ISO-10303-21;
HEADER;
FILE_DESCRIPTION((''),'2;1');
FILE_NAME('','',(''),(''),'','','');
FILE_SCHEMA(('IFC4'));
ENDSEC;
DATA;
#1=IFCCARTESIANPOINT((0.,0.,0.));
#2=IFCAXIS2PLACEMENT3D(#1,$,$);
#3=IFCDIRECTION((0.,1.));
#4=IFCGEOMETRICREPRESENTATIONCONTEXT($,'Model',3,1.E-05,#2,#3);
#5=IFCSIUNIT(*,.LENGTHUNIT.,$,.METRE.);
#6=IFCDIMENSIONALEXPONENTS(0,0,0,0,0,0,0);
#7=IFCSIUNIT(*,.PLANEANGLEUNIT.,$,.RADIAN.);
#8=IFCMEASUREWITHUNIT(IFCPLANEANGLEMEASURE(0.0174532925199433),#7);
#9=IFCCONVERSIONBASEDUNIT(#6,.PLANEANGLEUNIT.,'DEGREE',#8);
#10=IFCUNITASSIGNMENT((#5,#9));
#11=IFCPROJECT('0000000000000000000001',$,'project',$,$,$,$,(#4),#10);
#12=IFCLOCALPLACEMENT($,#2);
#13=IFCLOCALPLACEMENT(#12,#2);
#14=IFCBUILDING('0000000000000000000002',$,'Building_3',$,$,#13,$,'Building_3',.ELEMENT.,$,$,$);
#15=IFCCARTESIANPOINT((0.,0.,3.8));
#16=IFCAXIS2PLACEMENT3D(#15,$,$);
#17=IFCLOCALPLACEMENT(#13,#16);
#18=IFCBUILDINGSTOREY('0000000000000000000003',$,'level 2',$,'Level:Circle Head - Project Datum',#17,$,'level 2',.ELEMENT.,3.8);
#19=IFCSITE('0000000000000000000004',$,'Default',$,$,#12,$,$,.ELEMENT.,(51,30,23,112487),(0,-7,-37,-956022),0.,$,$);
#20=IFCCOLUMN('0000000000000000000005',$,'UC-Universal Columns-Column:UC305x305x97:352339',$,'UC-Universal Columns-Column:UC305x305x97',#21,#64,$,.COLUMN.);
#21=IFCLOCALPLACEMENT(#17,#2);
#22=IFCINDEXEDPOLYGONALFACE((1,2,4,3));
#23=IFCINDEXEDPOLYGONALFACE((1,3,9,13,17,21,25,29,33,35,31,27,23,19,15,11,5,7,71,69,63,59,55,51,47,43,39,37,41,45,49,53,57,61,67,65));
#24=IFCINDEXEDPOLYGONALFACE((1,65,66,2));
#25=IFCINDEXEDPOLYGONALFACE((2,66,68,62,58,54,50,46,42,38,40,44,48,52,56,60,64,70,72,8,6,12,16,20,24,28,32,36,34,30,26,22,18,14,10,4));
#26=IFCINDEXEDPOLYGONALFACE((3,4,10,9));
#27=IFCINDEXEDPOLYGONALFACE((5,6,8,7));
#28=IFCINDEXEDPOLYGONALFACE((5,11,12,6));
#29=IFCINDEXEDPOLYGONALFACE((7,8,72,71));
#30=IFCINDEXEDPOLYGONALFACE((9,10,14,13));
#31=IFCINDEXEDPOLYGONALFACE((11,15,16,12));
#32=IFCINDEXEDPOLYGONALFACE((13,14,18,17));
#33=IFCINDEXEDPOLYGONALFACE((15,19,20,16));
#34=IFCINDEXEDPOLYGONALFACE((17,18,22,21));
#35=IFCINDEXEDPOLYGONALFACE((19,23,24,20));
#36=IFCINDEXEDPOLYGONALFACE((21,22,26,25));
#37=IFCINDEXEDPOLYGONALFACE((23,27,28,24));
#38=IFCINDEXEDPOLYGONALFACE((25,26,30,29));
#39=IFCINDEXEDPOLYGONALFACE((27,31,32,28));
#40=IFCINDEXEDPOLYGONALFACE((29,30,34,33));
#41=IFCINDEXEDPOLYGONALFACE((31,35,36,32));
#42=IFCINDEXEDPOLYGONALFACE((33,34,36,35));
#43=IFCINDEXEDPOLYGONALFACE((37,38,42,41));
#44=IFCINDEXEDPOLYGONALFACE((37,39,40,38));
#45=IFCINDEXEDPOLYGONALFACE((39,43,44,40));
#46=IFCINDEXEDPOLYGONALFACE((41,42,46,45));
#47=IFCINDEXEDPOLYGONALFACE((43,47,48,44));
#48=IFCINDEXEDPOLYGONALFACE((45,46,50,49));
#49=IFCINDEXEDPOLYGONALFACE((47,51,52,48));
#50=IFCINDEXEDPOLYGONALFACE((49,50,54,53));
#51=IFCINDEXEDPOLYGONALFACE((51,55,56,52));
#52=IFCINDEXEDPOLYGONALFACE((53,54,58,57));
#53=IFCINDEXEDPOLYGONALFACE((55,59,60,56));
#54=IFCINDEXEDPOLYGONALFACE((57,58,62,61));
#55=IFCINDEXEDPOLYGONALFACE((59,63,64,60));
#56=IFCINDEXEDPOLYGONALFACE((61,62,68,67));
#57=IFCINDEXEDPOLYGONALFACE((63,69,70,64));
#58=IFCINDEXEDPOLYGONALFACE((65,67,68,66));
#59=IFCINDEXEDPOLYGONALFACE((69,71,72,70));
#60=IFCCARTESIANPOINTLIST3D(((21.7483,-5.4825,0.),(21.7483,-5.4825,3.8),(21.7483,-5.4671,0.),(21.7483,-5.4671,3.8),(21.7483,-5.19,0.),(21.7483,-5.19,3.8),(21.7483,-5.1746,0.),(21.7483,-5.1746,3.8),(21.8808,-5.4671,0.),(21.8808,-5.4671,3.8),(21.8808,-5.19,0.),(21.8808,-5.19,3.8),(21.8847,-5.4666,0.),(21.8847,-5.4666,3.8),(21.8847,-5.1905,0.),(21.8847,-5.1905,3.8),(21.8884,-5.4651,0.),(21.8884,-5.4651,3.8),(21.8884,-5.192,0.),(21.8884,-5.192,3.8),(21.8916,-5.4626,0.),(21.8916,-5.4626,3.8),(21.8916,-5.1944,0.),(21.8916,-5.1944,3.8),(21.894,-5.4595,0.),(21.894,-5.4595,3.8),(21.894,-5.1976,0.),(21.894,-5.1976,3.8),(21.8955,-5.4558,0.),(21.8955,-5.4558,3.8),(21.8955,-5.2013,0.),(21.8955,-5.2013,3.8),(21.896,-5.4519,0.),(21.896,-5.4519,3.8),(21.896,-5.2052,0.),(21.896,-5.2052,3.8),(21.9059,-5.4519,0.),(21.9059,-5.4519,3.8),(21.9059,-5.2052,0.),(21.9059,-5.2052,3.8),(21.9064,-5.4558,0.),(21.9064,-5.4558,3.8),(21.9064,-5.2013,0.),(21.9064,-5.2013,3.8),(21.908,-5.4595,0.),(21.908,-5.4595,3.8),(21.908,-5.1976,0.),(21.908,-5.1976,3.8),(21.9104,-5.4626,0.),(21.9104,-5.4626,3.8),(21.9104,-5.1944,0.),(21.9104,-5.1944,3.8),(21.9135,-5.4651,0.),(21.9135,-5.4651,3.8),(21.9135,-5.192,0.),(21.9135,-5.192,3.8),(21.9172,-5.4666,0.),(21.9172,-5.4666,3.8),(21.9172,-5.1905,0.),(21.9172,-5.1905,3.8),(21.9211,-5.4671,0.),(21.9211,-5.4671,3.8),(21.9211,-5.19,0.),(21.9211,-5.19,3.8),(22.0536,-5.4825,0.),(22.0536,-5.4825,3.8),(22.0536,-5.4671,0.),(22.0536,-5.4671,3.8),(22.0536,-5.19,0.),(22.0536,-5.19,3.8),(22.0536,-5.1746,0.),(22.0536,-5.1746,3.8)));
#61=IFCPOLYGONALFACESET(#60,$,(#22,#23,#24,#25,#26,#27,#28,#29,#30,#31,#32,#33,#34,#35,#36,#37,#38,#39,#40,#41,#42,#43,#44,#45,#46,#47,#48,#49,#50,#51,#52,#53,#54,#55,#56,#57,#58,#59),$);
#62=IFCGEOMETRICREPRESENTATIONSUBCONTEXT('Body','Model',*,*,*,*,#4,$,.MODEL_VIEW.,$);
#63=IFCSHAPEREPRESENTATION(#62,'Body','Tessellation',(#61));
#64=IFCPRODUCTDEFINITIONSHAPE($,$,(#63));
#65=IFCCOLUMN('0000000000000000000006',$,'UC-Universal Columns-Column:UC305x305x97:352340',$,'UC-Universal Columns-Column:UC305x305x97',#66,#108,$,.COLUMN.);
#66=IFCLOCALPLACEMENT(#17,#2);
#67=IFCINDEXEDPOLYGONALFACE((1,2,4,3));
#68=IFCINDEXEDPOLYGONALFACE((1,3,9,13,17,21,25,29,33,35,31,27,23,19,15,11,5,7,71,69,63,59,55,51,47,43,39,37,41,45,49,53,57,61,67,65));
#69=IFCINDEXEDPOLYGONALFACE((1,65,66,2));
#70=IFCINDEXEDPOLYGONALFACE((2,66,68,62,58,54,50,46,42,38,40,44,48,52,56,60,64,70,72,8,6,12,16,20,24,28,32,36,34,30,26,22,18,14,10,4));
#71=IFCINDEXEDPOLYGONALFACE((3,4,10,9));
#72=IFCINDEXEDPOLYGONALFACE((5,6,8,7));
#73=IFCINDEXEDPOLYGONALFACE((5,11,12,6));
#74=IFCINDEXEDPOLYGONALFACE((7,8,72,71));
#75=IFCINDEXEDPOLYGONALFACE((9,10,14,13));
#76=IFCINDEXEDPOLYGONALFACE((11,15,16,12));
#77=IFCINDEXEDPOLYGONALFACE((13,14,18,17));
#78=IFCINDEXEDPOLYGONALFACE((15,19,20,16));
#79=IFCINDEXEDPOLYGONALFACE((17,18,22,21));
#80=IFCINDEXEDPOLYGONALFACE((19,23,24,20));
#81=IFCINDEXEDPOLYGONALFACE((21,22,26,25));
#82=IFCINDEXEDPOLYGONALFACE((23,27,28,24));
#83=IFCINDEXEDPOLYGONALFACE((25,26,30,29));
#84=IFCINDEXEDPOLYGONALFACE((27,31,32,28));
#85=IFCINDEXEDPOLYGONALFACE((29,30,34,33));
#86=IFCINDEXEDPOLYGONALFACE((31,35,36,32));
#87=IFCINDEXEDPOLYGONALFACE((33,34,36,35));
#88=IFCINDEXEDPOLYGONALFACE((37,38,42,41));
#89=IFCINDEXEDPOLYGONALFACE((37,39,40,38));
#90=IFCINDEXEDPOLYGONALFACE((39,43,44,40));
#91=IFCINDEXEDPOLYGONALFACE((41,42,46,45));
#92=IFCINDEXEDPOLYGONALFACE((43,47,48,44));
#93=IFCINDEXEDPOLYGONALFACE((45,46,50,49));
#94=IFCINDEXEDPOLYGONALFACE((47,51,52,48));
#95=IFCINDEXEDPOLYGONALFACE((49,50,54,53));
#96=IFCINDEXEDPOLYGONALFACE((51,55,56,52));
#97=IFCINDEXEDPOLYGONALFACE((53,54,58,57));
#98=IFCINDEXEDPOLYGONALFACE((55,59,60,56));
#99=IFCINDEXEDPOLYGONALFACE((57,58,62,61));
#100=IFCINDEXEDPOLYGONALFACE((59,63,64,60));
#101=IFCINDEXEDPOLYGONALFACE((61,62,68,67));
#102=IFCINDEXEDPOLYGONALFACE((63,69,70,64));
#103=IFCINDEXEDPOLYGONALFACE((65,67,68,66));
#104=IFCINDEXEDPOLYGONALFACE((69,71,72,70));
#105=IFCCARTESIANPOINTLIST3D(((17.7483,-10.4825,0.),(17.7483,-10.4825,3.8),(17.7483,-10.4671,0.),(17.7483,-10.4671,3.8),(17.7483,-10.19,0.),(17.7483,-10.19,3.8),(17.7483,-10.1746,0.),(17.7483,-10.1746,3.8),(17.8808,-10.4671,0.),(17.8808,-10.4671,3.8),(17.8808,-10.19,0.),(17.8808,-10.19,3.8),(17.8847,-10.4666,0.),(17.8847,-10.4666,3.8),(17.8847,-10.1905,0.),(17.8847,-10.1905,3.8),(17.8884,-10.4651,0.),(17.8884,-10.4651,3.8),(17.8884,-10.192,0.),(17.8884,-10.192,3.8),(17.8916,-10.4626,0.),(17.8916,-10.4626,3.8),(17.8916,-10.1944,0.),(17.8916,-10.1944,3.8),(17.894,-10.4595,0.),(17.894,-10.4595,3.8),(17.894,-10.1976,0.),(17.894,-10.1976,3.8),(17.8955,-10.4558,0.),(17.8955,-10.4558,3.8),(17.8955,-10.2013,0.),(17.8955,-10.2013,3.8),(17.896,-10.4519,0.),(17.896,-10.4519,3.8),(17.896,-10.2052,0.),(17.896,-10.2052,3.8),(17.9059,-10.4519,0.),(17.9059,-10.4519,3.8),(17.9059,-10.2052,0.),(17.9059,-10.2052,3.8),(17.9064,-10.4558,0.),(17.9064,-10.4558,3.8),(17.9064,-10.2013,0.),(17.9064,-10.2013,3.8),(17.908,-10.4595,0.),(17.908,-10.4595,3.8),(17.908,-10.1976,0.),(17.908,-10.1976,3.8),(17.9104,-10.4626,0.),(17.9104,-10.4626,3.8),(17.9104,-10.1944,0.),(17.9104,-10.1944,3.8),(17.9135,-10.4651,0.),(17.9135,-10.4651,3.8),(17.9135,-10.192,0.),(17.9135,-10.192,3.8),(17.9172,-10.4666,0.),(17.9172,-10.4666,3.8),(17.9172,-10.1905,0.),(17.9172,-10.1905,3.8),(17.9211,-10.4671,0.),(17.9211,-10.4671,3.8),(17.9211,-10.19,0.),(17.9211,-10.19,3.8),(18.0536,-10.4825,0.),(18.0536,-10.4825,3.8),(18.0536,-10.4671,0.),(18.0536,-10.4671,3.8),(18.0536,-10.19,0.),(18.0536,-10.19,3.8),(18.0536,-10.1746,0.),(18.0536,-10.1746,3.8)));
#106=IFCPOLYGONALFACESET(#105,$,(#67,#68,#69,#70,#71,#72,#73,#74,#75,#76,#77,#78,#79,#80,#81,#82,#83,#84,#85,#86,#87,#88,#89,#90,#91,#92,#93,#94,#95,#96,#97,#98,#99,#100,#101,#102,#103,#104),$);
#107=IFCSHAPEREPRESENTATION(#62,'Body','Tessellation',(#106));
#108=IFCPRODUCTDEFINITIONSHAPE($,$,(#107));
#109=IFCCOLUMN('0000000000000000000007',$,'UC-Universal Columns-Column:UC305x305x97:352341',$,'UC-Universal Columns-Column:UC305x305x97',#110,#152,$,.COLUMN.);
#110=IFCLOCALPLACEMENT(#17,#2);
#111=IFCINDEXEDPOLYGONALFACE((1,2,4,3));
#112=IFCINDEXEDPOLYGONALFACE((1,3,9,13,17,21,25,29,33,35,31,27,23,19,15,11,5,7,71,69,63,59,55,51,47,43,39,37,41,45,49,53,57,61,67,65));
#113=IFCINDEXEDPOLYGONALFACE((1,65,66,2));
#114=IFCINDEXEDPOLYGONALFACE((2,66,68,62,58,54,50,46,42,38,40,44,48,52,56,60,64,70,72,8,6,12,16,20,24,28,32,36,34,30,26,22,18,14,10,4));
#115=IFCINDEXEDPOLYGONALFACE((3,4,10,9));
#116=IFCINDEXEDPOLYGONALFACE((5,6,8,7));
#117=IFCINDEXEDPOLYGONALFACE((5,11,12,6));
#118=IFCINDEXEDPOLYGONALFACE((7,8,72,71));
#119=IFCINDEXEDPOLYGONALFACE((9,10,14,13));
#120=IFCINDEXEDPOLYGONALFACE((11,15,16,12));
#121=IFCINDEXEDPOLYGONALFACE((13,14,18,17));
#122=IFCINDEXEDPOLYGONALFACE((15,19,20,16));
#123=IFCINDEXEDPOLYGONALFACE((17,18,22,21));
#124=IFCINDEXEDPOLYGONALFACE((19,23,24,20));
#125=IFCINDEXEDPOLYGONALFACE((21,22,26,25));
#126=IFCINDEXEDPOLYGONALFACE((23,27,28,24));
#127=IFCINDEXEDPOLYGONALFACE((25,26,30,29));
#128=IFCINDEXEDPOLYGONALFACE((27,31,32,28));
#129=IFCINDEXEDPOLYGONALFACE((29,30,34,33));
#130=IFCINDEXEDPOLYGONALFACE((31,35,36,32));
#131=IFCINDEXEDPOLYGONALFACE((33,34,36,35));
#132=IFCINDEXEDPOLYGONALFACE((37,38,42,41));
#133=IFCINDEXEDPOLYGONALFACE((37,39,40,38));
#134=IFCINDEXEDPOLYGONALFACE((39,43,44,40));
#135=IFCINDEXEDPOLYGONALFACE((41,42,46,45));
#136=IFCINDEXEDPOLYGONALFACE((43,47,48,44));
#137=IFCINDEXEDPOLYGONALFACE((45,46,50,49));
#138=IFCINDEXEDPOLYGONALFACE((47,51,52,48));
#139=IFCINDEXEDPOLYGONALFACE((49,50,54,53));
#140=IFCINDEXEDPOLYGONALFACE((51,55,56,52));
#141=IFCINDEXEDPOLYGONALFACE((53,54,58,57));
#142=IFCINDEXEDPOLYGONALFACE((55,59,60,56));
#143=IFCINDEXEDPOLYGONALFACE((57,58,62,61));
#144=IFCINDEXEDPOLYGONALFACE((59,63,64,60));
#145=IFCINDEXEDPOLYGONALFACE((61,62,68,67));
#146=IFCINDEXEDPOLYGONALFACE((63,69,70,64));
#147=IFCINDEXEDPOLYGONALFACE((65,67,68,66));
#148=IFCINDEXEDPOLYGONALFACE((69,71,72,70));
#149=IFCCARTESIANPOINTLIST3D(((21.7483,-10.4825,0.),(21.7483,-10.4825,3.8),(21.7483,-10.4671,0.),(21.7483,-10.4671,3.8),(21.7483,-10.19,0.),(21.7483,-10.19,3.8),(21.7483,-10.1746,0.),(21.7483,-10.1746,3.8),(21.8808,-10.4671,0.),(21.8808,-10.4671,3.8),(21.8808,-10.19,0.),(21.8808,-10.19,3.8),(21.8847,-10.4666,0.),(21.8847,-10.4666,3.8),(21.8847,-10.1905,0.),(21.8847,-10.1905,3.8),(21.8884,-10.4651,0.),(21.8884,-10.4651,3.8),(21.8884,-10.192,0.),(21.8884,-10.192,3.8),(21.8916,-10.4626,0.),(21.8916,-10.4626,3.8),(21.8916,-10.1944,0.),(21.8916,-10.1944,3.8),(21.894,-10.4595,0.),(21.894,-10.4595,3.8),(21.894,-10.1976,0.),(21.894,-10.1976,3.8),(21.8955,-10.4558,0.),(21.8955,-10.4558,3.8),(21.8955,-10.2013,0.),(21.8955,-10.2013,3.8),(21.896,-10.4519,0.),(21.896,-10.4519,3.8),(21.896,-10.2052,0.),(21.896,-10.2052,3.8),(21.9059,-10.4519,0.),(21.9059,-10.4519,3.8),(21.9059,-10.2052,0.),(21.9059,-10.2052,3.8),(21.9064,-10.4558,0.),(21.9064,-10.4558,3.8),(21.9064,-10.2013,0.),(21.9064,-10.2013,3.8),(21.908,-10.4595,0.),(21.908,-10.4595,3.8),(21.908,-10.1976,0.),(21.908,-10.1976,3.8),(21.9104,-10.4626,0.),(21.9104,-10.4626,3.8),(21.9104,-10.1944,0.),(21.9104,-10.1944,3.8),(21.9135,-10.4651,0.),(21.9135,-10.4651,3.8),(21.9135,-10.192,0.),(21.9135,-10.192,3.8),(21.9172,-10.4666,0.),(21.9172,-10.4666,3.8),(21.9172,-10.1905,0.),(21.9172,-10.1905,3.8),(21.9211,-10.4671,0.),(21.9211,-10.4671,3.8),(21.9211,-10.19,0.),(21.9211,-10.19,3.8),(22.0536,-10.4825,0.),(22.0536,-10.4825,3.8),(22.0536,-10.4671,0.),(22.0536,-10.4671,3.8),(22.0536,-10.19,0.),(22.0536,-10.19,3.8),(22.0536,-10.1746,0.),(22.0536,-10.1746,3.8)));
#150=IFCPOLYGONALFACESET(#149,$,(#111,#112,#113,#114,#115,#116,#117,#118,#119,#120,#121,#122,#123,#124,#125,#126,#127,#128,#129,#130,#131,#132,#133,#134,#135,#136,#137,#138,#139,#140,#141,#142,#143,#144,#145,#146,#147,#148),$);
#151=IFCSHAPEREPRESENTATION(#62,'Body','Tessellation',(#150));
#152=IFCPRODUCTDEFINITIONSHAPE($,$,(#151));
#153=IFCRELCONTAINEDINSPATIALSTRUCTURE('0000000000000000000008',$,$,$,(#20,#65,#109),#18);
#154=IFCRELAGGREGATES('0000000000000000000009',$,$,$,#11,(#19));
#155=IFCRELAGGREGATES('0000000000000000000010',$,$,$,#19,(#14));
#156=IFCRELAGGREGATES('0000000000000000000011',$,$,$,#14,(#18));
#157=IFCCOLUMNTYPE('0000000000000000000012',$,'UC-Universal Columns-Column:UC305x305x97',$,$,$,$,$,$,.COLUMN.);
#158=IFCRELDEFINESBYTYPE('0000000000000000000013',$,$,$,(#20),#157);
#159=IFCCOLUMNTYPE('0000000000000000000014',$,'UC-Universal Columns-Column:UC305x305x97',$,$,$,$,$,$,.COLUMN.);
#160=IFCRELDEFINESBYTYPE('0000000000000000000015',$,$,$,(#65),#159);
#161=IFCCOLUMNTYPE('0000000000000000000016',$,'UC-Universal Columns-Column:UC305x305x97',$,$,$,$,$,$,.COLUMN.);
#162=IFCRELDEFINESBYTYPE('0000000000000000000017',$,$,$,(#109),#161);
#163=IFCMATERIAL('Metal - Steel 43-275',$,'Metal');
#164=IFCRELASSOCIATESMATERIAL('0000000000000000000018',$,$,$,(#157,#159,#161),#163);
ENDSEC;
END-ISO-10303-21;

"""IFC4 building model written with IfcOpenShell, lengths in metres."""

from ifc_helpers import new_model, entity, si_unit, converted_unit, direction, frame, frame_2d, origin, place, context, subcontext, project, spatial, i_section, extrude, source, transform, mapped, material, material_profile, profile_set, type_object, type_shapes, element, save


model = new_model("IFC4")

# Units and contexts
model_context = context("Model", 3, precision=1e-05, world=origin(), true_north=direction((0.0, 1.0)))
body_context = subcontext(model_context, "Body", "Model", "MODEL_VIEW")
ifc_project = project(units=[si_unit("LENGTHUNIT", "METRE"), converted_unit("PLANEANGLEUNIT", "DEGREE", entity("IfcPlaneAngleMeasure", 0.0174532925199433), si_unit("PLANEANGLEUNIT", "RADIAN"), dimensions=[0, 0, 0, 0, 0, 0, 0])], contexts=[model_context])

# Site, building, storey
site_placement = place(None, origin())
site = spatial("IfcSite", under=ifc_project, at=site_placement, Name="Default", CompositionType="ELEMENT", RefLatitude=(51, 30, 23, 112487), RefLongitude=(0, -7, -37, -956022), RefElevation=0.0)
building_placement = place(site_placement, origin())
building = spatial("IfcBuilding", under=site, at=building_placement, Name="Building_3", LongName="Building_3", CompositionType="ELEMENT")
storey_placement = place(building_placement, frame((0.0, 0.0, 3.8)))
storey = spatial("IfcBuildingStorey", under=building, at=storey_placement, Name="level 2", ObjectType="Level:Circle Head - Project Datum", LongName="level 2", CompositionType="ELEMENT", Elevation=3.8)

# Columns
ifc_material_1 = material(Name="Metal - Steel 43-275", Category="Metal")
ifc_material_profile_1 = material_profile(ifc_material_1, i_section(OverallWidth=0.3053, OverallDepth=0.3079, WebThickness=0.0099, FlangeThickness=0.0154, FilletRadius=0.0152, at=frame_2d((0.0, 0.0), x_axis=(1.0, 0.0))), Name="UC305x305x97")
ifc_profile_set_1 = profile_set([ifc_material_profile_1], Name="UC305x305x97")
column_type_1 = type_object("IfcColumnType", Name="UC-Universal Columns-Column:UC305x305x97", PredefinedType="COLUMN", material=ifc_profile_set_1)
shared_shape_1 = source(origin(), body_context, "Body", "SweptSolid", [
    extrude(i_section(OverallWidth=0.3053, OverallDepth=0.3079, WebThickness=0.0099, FlangeThickness=0.0154, FilletRadius=0.0152, at=frame_2d((0.0, 0.0), x_axis=(1.0, 0.0))), frame((21.901, -5.3285, 3.8), z_axis=(0.0, 0.0, 1.0), x_axis=(-1.0, 0.0, 0.0)), (0.0, 0.0, 1.0), 3.8),
])
type_shapes(column_type_1, [shared_shape_1])
column_1_placement = place(storey_placement, frame((0.0, 0.0, -3.8)))
element("IfcColumn", 1, at=column_1_placement, inside=storey, type_object=column_type_1, Name="UC-Universal Columns-Column:UC305x305x97:352339", ObjectType="UC-Universal Columns-Column:UC305x305x97", PredefinedType="COLUMN", context=body_context, shape_type="MappedRepresentation", body=[
    mapped(shared_shape_1, transform((0.0, 0.0, 0.0), scale=1.0)),
])
column_type_2 = type_object("IfcColumnType", Name="UC-Universal Columns-Column:UC305x305x97", PredefinedType="COLUMN", material=ifc_profile_set_1)
shared_shape_2 = source(origin(), body_context, "Body", "SweptSolid", [
    extrude(i_section(OverallWidth=0.3053, OverallDepth=0.3079, WebThickness=0.0099, FlangeThickness=0.0154, FilletRadius=0.0152, at=frame_2d((0.0, 0.0), x_axis=(1.0, 0.0))), frame((17.901, -10.3285, 3.8), z_axis=(0.0, 0.0, 1.0), x_axis=(-1.0, 0.0, 0.0)), (0.0, 0.0, 1.0), 3.8),
])
type_shapes(column_type_2, [shared_shape_2])
column_2_placement = place(storey_placement, frame((0.0, 0.0, -3.8)))
element("IfcColumn", 2, at=column_2_placement, inside=storey, type_object=column_type_2, Name="UC-Universal Columns-Column:UC305x305x97:352340", ObjectType="UC-Universal Columns-Column:UC305x305x97", PredefinedType="COLUMN", context=body_context, shape_type="MappedRepresentation", body=[
    mapped(shared_shape_2, transform((0.0, 0.0, 0.0), scale=1.0)),
])
column_type_3 = type_object("IfcColumnType", Name="UC-Universal Columns-Column:UC305x305x97", PredefinedType="COLUMN", material=ifc_profile_set_1)
shared_shape_3 = source(origin(), body_context, "Body", "SweptSolid", [
    extrude(i_section(OverallWidth=0.3053, OverallDepth=0.3079, WebThickness=0.0099, FlangeThickness=0.0154, FilletRadius=0.0152, at=frame_2d((0.0, 0.0), x_axis=(1.0, 0.0))), frame((21.901, -10.3285, 3.8), z_axis=(0.0, 0.0, 1.0), x_axis=(-1.0, 0.0, 0.0)), (0.0, 0.0, 1.0), 3.8),
])
type_shapes(column_type_3, [shared_shape_3])
column_3_placement = place(storey_placement, frame((0.0, 0.0, -3.8)))
element("IfcColumn", 3, at=column_3_placement, inside=storey, type_object=column_type_3, Name="UC-Universal Columns-Column:UC305x305x97:352341", ObjectType="UC-Universal Columns-Column:UC305x305x97", PredefinedType="COLUMN", context=body_context, shape_type="MappedRepresentation", body=[
    mapped(shared_shape_3, transform((0.0, 0.0, 0.0), scale=1.0)),
])

save(model, "model.ifc")
